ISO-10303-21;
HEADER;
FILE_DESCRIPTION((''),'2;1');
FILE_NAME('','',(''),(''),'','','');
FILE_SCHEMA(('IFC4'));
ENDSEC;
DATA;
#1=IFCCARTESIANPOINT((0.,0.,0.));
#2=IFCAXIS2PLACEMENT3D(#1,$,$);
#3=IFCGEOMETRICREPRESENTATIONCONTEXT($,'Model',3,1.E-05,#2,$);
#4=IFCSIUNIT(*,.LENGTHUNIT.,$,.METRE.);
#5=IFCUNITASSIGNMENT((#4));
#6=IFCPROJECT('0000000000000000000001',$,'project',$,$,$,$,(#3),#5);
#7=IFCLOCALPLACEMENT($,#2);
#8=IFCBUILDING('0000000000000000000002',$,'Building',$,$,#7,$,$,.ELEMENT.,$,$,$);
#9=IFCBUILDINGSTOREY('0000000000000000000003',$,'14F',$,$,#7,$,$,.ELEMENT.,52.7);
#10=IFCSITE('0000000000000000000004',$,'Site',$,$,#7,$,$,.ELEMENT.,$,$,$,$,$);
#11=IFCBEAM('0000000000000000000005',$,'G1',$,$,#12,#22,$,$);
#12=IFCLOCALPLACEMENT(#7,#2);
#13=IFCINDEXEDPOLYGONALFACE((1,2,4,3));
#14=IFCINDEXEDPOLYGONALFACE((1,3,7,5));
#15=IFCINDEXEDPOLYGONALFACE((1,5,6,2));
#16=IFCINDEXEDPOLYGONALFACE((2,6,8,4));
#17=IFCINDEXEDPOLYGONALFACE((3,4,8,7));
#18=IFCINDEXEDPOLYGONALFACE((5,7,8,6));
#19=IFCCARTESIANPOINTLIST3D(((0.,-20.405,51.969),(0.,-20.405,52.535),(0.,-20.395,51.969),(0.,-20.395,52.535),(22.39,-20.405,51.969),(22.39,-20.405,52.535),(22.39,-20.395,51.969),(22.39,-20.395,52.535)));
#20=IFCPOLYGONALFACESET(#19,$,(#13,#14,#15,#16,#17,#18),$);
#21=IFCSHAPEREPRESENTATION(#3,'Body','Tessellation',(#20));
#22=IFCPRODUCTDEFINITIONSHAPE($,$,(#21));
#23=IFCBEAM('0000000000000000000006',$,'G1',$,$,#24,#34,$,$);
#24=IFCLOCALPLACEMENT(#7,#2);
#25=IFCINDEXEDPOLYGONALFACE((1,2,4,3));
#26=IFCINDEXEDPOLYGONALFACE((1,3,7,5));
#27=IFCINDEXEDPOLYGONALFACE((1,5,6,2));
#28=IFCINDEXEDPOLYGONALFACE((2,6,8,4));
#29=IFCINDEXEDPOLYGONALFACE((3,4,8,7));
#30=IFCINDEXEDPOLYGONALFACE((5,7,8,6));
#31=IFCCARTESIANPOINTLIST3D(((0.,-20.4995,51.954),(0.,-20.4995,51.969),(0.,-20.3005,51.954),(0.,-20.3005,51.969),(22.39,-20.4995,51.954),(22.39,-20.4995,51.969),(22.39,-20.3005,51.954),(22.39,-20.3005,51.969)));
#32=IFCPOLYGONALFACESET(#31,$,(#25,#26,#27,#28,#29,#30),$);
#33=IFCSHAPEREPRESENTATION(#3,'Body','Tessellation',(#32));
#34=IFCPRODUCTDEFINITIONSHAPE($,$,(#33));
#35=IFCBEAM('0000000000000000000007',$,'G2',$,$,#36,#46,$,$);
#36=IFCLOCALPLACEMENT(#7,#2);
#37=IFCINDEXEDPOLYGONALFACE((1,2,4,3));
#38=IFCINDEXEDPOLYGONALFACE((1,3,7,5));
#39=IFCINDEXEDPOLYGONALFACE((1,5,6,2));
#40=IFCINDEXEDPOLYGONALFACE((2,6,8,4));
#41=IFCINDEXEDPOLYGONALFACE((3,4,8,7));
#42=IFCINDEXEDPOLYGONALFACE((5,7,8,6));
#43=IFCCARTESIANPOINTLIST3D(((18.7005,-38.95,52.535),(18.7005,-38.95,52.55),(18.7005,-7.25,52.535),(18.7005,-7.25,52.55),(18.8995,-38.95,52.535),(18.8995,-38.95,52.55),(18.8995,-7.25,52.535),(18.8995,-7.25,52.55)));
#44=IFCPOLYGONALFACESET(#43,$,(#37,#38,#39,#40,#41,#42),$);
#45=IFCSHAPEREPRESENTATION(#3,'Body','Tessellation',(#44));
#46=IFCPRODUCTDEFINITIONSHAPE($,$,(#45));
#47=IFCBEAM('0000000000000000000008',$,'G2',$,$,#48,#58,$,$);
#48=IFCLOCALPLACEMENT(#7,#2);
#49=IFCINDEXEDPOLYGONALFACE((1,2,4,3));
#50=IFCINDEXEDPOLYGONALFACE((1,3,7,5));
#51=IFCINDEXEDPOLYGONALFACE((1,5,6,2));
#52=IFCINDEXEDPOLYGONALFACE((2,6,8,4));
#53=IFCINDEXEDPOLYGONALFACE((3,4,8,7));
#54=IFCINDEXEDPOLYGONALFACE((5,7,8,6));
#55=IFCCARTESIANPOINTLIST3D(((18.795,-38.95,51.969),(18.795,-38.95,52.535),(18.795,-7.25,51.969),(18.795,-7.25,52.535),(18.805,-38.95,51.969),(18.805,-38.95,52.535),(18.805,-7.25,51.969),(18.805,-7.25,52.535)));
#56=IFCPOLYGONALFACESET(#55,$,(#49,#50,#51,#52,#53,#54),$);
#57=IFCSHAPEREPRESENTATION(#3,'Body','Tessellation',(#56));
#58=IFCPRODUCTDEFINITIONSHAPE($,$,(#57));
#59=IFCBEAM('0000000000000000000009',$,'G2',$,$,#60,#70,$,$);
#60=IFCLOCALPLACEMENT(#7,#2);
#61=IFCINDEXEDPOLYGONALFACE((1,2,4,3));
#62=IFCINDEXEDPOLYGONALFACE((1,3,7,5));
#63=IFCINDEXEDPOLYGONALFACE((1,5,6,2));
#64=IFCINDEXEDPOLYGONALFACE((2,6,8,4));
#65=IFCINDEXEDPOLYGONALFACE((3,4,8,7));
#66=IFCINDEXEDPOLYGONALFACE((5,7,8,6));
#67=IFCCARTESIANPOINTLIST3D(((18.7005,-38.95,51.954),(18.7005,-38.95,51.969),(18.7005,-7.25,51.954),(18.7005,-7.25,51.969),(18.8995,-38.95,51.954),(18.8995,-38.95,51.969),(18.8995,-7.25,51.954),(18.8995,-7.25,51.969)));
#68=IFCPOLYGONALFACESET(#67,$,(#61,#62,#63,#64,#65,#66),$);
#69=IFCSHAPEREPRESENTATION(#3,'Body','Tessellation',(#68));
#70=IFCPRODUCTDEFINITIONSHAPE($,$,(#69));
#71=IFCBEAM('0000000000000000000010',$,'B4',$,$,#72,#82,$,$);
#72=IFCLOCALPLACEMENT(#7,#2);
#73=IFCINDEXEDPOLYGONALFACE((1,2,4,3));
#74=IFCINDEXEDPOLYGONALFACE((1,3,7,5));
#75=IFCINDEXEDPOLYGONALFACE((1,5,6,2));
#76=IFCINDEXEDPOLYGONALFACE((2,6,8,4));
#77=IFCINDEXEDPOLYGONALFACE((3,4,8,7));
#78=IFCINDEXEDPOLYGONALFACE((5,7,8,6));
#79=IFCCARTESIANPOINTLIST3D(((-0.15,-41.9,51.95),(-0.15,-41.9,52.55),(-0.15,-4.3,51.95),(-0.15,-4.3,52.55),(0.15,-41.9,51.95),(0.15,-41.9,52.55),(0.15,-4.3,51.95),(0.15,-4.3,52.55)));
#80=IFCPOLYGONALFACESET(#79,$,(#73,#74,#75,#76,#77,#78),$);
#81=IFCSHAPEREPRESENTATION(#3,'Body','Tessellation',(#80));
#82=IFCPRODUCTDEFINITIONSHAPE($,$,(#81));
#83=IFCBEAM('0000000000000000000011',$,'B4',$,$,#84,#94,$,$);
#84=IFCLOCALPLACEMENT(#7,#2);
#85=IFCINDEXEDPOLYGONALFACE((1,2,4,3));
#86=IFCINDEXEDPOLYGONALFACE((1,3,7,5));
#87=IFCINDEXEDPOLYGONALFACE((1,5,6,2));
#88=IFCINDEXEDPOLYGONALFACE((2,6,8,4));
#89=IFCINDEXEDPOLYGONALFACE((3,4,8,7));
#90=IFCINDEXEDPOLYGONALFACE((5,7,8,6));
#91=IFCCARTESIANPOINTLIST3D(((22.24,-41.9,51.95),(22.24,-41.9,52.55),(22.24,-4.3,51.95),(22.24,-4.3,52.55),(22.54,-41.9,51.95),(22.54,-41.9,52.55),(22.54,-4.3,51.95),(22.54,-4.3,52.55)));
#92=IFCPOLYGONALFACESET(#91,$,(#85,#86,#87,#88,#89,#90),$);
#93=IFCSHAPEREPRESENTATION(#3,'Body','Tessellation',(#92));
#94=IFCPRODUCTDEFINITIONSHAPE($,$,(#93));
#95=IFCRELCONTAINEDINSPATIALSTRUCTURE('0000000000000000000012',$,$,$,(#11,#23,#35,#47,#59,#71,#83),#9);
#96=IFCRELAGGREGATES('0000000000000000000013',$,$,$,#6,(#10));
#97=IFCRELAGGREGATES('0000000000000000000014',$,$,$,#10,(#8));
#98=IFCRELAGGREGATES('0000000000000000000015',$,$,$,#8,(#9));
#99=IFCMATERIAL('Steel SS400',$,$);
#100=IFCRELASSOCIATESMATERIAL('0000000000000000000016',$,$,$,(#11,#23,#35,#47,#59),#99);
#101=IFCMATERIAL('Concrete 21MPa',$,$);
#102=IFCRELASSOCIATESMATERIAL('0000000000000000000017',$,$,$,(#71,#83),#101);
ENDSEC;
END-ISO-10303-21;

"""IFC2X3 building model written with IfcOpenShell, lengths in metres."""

from ifc_helpers import new_model, si_unit, frame, origin, origin_2d, place, context, project, spatial, rectangle, extrude, material, element, save


model = new_model("IFC2X3")

# Units and contexts
model_context = context("Model", 3, precision=1e-05, world=origin())
ifc_project = project(units=[si_unit("LENGTHUNIT", "METRE")], contexts=[model_context])

# Site, building, storey
placement = place(None, origin())
site = spatial("IfcSite", under=ifc_project, at=placement, Name="Site", CompositionType="ELEMENT")
building = spatial("IfcBuilding", under=site, at=placement, Name="Building", CompositionType="ELEMENT")
storey = spatial("IfcBuildingStorey", under=building, at=placement, Name="14F", CompositionType="ELEMENT", Elevation=52.7)

# Shared definitions
ifc_material_1 = material(Name="Concrete 21MPa")
ifc_material_2 = material(Name="Steel SS400")

# Beams
beam_1_placement = place(None, frame((11.195, -20.4, 51.969)))
element("IfcBeam", 1, at=beam_1_placement, inside=storey, material=ifc_material_2, Name="G1", context=model_context, shape_type="SweptSolid", body=[
    extrude(rectangle(XDim=22.39, YDim=0.01, at=origin_2d()), origin(), (0.0, 0.0, 1.0), 0.566),
])
beam_2_placement = place(None, frame((11.195, -20.4, 51.954)))
element("IfcBeam", 2, at=beam_2_placement, inside=storey, material=ifc_material_2, Name="G1", context=model_context, shape_type="SweptSolid", body=[
    extrude(rectangle(XDim=22.39, YDim=0.199, at=origin_2d()), origin(), (0.0, 0.0, 1.0), 0.015),
])
beam_3_placement = place(None, frame((18.8, -23.1, 52.535)))
element("IfcBeam", 3, at=beam_3_placement, inside=storey, material=ifc_material_2, Name="G2", context=model_context, shape_type="SweptSolid", body=[
    extrude(rectangle(XDim=0.199, YDim=31.7, at=origin_2d()), origin(), (0.0, 0.0, 1.0), 0.015),
])
beam_4_placement = place(None, frame((18.8, -23.1, 51.969)))
element("IfcBeam", 4, at=beam_4_placement, inside=storey, material=ifc_material_2, Name="G2", context=model_context, shape_type="SweptSolid", body=[
    extrude(rectangle(XDim=0.01, YDim=31.7, at=origin_2d()), origin(), (0.0, 0.0, 1.0), 0.566),
])
beam_5_placement = place(None, frame((18.8, -23.1, 51.954)))
element("IfcBeam", 5, at=beam_5_placement, inside=storey, material=ifc_material_2, Name="G2", context=model_context, shape_type="SweptSolid", body=[
    extrude(rectangle(XDim=0.199, YDim=31.7, at=origin_2d()), origin(), (0.0, 0.0, 1.0), 0.015),
])
for number, where, name in (
    (6, (0.0, -23.1, 51.95), "B4"),
    (7, (22.39, -23.1, 51.95), "B4"),
):
    element("IfcBeam", number, at=place(None, frame(where)), inside=storey, material=ifc_material_1, Name=name, context=model_context, shape_type="SweptSolid", body=[
        extrude(rectangle(XDim=0.3, YDim=37.6, at=origin_2d()), origin(), (0.0, 0.0, 1.0), 0.6),
    ])

save(model, "model.ifc")
